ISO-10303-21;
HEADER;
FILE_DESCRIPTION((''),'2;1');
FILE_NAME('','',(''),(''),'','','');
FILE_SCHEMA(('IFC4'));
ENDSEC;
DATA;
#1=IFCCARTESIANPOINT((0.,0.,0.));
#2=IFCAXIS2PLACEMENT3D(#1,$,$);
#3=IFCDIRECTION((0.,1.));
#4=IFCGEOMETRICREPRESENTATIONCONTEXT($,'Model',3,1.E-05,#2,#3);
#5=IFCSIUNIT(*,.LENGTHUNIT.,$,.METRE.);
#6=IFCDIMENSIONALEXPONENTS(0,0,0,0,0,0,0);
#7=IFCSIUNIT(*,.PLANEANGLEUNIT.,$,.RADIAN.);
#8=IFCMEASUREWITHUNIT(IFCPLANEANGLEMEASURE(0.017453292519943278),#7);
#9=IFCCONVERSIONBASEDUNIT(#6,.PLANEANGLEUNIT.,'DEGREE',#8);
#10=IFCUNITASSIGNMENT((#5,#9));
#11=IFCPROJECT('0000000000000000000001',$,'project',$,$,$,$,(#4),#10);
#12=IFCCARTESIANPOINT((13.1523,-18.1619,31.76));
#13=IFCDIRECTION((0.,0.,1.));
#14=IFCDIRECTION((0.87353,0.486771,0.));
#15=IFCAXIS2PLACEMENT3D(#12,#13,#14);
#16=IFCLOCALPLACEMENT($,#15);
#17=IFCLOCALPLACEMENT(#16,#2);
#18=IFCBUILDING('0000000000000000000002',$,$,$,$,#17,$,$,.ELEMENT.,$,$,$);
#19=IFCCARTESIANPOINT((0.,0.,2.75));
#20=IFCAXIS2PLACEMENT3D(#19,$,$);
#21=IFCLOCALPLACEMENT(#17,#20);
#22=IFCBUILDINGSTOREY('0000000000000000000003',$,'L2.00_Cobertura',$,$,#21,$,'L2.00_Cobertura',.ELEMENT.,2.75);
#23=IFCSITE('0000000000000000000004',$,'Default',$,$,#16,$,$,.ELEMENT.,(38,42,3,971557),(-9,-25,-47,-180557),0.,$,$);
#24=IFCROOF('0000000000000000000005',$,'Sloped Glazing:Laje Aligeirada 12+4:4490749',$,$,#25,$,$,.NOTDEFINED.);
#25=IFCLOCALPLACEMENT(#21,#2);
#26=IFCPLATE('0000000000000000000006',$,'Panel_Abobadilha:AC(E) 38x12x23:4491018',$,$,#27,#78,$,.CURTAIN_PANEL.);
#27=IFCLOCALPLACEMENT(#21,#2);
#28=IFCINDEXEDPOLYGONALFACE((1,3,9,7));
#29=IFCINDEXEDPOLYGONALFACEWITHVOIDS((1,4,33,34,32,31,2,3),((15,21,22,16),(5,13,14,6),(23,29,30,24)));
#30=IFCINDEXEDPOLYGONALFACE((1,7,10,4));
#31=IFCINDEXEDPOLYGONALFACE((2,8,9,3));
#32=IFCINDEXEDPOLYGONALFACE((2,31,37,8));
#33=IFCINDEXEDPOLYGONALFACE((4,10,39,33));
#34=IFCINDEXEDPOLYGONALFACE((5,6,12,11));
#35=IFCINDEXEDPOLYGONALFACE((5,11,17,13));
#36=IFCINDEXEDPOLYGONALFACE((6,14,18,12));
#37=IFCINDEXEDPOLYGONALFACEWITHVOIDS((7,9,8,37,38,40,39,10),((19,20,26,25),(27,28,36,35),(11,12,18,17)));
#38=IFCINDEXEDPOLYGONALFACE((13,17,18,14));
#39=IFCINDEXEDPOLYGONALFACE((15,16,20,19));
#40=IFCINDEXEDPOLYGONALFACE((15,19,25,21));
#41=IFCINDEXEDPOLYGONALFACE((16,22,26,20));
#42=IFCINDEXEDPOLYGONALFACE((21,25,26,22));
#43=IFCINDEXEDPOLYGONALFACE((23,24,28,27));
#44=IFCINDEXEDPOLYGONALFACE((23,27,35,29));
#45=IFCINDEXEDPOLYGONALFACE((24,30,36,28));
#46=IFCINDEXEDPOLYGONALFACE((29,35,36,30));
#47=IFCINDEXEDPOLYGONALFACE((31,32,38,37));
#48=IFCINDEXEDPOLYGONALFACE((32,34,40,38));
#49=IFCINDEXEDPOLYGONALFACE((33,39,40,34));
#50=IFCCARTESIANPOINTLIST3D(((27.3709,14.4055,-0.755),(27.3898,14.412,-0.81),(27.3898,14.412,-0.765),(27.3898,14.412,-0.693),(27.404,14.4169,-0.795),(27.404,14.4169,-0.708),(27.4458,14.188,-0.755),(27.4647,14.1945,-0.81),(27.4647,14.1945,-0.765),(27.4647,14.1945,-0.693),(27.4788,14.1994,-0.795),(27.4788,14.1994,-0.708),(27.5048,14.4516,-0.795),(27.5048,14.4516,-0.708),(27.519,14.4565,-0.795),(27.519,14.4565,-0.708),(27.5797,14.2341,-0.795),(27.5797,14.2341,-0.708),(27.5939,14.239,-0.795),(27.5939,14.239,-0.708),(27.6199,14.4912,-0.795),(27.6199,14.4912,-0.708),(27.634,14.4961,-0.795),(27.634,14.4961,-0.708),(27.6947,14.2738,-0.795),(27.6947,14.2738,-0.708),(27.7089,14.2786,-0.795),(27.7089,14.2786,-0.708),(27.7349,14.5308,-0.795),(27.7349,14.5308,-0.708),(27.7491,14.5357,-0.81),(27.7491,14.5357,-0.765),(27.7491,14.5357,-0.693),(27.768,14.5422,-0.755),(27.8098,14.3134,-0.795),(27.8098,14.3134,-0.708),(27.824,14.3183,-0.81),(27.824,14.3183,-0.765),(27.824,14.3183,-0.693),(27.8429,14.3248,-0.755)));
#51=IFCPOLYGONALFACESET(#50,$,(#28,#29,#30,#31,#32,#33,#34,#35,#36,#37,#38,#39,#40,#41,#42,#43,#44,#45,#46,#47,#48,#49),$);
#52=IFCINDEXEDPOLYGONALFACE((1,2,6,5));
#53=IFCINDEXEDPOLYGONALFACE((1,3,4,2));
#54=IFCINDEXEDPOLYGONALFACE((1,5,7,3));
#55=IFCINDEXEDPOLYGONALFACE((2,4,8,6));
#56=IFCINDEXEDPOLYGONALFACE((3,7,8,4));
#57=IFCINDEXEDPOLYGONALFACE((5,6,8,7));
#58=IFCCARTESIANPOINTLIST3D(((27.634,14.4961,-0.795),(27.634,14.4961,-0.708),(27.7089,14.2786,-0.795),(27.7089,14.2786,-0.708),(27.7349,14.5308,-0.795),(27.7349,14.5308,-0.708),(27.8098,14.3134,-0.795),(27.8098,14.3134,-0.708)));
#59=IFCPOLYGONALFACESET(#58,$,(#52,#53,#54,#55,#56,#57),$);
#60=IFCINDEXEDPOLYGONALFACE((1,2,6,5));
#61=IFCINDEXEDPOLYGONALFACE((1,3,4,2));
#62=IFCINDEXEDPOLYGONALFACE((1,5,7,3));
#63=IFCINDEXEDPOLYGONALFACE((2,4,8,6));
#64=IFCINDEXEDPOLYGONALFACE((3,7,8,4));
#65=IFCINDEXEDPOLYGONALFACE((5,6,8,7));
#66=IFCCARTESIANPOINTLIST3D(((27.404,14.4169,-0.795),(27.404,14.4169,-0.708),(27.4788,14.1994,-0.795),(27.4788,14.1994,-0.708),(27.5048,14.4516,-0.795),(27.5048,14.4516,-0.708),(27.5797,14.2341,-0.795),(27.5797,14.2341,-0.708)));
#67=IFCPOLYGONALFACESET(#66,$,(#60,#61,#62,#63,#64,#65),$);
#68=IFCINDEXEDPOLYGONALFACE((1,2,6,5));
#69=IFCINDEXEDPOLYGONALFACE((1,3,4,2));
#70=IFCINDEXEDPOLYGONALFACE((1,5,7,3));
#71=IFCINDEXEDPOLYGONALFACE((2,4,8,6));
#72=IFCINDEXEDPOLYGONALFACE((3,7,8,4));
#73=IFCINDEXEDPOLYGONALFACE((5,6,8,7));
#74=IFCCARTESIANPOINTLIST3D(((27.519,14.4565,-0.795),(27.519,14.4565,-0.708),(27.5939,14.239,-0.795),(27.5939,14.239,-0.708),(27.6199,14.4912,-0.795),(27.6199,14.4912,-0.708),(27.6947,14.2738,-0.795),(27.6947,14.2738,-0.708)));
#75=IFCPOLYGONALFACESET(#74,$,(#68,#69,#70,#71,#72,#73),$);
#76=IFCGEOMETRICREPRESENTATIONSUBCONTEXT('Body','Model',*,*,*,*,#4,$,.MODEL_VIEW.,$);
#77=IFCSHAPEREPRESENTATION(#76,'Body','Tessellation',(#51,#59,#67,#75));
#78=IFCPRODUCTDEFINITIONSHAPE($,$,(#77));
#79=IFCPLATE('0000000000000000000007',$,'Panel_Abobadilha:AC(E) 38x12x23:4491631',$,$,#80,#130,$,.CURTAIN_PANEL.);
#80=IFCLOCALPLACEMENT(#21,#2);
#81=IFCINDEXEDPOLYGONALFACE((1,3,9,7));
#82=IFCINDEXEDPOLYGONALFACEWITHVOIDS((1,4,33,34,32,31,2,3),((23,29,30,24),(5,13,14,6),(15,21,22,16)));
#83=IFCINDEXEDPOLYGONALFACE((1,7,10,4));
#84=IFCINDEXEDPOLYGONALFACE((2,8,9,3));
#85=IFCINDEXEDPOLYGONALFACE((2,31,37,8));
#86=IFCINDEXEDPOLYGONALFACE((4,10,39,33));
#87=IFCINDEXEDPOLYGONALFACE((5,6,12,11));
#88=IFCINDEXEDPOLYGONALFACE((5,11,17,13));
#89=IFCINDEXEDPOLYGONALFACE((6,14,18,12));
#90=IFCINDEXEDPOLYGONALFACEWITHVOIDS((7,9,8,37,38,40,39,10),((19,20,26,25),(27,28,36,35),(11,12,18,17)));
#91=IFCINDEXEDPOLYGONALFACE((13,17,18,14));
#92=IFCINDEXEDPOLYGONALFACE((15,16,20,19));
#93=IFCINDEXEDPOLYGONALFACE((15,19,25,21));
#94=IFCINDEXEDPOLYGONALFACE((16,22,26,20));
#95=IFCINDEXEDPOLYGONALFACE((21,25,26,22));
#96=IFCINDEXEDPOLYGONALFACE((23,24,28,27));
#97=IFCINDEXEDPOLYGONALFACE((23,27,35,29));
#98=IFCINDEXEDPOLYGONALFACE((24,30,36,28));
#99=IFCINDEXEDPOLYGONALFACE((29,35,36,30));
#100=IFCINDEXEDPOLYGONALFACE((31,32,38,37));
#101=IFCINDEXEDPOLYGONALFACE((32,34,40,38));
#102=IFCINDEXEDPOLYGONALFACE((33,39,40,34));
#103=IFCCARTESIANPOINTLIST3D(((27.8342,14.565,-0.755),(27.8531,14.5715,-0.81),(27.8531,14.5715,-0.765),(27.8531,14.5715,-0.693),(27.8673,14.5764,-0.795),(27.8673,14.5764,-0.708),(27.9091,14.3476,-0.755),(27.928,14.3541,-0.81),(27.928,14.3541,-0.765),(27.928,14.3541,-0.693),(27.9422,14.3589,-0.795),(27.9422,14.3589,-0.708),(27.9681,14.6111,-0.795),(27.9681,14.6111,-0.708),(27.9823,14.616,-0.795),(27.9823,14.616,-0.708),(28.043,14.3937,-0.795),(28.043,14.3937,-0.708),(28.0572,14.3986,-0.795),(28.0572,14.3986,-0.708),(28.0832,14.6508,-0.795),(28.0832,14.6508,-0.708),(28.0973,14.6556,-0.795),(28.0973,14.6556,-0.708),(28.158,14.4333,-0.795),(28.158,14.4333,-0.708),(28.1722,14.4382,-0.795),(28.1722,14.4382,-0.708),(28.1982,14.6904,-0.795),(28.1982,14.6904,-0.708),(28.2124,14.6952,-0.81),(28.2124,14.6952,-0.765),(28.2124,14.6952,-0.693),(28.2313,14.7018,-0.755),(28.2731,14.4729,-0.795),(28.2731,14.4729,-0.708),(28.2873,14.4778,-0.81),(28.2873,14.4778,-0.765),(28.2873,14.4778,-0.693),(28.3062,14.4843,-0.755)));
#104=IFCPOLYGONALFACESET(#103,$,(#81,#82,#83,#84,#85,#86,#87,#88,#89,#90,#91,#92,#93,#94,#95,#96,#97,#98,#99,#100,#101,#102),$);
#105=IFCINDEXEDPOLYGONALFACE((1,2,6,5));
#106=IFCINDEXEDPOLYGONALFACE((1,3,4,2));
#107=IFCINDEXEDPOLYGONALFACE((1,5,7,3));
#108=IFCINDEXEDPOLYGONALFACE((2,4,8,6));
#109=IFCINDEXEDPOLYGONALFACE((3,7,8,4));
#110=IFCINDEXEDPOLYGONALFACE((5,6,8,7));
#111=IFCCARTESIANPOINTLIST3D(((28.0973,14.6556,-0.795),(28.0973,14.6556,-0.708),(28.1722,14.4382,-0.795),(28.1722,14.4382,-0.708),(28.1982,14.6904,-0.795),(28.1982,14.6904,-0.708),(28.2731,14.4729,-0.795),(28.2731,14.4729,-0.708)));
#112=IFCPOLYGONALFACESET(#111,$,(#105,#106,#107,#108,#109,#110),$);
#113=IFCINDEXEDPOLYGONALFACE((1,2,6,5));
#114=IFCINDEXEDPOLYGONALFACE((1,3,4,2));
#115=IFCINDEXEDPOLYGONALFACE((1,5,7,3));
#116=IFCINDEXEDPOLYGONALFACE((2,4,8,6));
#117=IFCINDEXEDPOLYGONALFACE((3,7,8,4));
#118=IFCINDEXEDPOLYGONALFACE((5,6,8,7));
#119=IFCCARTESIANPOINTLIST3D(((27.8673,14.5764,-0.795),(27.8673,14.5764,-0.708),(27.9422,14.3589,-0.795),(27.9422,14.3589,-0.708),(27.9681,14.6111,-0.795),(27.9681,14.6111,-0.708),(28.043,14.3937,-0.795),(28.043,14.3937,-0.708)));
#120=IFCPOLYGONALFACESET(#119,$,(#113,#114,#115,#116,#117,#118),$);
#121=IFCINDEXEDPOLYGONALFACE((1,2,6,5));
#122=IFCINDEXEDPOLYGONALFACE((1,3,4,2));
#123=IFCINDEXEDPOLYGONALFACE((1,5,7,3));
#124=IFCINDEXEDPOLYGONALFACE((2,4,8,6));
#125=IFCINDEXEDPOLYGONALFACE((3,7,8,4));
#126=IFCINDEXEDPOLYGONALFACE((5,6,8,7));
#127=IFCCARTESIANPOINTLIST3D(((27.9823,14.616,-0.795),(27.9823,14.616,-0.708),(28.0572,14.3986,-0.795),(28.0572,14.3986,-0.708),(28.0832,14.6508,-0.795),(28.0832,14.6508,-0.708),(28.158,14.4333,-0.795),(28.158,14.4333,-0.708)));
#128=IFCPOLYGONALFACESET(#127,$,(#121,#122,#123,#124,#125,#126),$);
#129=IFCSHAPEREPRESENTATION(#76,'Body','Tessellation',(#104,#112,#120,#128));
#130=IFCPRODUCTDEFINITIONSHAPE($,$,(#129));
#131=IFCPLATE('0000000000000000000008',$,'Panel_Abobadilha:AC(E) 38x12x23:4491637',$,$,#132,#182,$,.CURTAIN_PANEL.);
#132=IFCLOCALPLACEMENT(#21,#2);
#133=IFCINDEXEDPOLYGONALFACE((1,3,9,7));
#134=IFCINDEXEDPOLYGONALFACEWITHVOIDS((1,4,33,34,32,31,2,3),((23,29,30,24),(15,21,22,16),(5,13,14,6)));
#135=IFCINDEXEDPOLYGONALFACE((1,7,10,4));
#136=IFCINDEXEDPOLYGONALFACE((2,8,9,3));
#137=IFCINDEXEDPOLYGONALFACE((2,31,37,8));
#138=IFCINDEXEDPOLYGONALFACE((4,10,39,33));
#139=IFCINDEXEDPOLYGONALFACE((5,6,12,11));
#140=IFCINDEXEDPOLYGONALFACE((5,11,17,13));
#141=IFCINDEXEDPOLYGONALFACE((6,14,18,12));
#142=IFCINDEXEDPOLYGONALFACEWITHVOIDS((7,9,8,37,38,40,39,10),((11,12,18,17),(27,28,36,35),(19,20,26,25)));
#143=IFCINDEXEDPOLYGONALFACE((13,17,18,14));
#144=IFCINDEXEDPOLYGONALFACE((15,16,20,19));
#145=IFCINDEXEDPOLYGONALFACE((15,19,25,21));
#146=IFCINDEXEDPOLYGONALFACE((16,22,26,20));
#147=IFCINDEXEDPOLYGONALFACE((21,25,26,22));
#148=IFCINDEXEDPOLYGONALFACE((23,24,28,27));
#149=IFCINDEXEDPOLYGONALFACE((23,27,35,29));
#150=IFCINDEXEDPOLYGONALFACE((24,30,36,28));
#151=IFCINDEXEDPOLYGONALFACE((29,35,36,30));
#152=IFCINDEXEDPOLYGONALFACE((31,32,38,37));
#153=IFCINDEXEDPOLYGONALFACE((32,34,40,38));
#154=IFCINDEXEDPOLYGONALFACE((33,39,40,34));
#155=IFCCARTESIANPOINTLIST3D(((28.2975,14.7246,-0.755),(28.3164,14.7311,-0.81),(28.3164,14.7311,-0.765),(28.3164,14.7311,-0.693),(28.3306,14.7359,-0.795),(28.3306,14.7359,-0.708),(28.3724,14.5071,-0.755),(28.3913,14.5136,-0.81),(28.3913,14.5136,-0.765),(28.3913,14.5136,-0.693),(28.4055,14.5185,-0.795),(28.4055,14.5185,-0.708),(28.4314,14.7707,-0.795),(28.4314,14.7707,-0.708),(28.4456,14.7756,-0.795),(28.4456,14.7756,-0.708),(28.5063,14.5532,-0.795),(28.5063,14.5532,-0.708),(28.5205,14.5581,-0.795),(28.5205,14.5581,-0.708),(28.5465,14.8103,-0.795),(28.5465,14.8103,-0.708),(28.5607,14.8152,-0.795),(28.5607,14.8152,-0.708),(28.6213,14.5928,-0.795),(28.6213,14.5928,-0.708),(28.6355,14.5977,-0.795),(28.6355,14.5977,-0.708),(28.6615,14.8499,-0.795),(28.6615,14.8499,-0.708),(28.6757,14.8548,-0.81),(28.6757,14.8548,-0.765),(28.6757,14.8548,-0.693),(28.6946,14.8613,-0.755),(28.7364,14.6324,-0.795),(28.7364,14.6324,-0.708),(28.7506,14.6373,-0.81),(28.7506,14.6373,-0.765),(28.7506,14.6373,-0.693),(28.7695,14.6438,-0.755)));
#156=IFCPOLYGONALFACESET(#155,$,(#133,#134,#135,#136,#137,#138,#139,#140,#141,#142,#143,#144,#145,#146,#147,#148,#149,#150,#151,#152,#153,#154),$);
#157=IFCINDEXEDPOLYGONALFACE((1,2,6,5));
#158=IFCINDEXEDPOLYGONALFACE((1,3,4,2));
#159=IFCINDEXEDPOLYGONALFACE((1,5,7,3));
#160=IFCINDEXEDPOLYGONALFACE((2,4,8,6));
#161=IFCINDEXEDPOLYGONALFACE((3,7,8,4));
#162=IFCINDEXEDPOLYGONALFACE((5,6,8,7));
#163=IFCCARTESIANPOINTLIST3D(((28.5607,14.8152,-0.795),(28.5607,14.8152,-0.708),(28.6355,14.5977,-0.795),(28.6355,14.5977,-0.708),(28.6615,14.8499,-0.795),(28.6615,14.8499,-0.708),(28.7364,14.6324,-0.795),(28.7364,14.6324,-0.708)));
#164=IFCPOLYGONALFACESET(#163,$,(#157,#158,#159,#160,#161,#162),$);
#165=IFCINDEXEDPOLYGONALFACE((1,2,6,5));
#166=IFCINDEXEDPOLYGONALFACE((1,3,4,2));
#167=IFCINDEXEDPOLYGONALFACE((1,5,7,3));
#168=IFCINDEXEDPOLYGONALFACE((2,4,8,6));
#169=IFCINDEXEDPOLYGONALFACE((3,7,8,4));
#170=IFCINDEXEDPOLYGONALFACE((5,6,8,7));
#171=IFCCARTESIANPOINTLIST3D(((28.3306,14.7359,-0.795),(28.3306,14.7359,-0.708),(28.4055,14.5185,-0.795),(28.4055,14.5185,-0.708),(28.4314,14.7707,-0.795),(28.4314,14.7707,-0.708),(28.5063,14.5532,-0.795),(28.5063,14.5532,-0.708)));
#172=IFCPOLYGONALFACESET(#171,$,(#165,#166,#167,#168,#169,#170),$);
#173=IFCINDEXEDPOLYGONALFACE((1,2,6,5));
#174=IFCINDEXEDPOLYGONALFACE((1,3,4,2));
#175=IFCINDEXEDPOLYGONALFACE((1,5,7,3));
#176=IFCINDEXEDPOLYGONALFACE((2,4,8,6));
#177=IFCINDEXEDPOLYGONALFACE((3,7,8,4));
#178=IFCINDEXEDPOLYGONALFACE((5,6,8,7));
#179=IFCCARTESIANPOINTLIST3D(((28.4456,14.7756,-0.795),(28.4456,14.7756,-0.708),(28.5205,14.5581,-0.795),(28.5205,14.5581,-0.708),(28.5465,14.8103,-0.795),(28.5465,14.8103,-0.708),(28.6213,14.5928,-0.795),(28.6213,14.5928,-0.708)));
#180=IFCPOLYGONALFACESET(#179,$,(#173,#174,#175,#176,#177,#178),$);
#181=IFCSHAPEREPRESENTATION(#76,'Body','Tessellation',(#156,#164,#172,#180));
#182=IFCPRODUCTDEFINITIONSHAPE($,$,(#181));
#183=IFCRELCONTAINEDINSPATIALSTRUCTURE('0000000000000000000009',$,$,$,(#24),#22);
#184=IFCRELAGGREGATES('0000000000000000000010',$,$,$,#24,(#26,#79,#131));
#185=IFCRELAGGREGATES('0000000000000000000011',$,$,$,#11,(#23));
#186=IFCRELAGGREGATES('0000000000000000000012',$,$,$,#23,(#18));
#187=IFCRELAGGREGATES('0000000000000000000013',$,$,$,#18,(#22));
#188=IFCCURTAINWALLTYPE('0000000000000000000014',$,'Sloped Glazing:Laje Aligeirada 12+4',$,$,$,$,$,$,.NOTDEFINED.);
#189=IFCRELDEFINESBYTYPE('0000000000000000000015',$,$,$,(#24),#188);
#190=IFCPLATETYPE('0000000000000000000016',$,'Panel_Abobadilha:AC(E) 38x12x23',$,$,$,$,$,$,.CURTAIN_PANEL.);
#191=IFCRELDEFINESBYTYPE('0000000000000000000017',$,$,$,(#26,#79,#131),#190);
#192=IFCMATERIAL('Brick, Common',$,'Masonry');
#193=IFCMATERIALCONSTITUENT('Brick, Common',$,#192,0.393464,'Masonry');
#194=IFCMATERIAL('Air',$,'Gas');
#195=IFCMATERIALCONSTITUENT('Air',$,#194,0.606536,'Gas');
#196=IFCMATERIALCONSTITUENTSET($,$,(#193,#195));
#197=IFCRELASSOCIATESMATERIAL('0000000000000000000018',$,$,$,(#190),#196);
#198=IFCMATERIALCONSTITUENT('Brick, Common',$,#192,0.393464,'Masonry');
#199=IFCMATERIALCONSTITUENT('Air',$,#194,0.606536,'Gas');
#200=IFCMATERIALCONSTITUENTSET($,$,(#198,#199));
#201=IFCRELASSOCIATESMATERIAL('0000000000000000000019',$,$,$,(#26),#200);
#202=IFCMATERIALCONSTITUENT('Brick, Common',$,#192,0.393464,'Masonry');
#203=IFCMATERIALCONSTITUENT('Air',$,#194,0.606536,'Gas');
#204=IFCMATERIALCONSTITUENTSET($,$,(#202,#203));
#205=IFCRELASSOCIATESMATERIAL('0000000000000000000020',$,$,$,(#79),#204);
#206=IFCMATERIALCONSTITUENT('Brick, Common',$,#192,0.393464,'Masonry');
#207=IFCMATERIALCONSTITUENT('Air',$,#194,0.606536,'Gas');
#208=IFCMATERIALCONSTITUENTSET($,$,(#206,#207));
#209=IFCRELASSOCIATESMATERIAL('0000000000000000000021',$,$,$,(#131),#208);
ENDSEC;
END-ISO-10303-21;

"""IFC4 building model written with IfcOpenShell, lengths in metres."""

from ifc_helpers import new_model, entity, si_unit, converted_unit, direction, frame, origin, place, context, subcontext, project, spatial, indexed_curve, outline, extrude, source, transform, mapped, material, constituent, constituent_set, type_object, type_shapes, element, aggregate, save


model = new_model("IFC4")

# Units and contexts
model_context = context("Model", 3, precision=1e-05, world=origin(), true_north=direction((0.0, 1.0)))
body_context = subcontext(model_context, "Body", "Model", "MODEL_VIEW")
ifc_project = project(units=[si_unit("LENGTHUNIT", "METRE"), converted_unit("PLANEANGLEUNIT", "DEGREE", entity("IfcPlaneAngleMeasure", 0.017453292519943278), si_unit("PLANEANGLEUNIT", "RADIAN"), dimensions=[0, 0, 0, 0, 0, 0, 0])], contexts=[model_context])

# Site, building, storey
site_placement = place(None, frame((13.1523, -18.1619, 31.76), z_axis=(0.0, 0.0, 1.0), x_axis=(0.87353, 0.486771, 0.0)))
site = spatial("IfcSite", under=ifc_project, at=site_placement, Name="Default", CompositionType="ELEMENT", RefLatitude=(38, 42, 3, 971557), RefLongitude=(-9, -25, -47, -180557), RefElevation=0.0)
building_placement = place(site_placement, origin())
building = spatial("IfcBuilding", under=site, at=building_placement, CompositionType="ELEMENT")
storey_placement = place(building_placement, frame((0.0, 0.0, 2.75)))
storey = spatial("IfcBuildingStorey", under=building, at=storey_placement, Name="L2.00_Cobertura", LongName="L2.00_Cobertura", CompositionType="ELEMENT", Elevation=2.75)

# Roof, plates
curtain_wall_type = type_object("IfcCurtainWallType", Name="Sloped Glazing:Laje Aligeirada 12+4", PredefinedType="NOTDEFINED")
roof_placement = place(storey_placement, frame((0.0, 0.0, -2.75)))
roof = element("IfcRoof", 1, at=roof_placement, inside=storey, type_object=curtain_wall_type, Name="Sloped Glazing:Laje Aligeirada 12+4:4490749", PredefinedType="NOTDEFINED")
ifc_material_1 = material(Name="Brick, Common", Category="Masonry")
ifc_material_2 = material(Name="Air", Category="Gas")
ifc_constituent_1 = constituent(ifc_material_1, Name="Brick, Common", Category="Masonry", fraction=0.393464)
ifc_constituent_2 = constituent(ifc_material_2, Name="Air", Category="Gas", fraction=0.606536)
ifc_constituent_set_1 = constituent_set(constituents=[ifc_constituent_1, ifc_constituent_2])
plate_type = type_object("IfcPlateType", Name="Panel_Abobadilha:AC(E) 38x12x23", PredefinedType="CURTAIN_PANEL", material=ifc_constituent_set_1)
shared_shape_1 = source(origin(), body_context, "Body", "SweptSolid", [
    extrude(outline(indexed_curve([(-0.19, -0.0543), (0.19, -0.0543), (0.19, -0.0093), (0.21, 0.0007), (0.19, 0.0628), (-0.19, 0.0628), (-0.21, 0.0007), (-0.19, -0.0093), (-0.19, -0.0543)], self_intersect=False), holes=[indexed_curve([(-0.0683, 0.0477), (-0.0683, -0.0393), (-0.175, -0.0393), (-0.175, 0.0477), (-0.0683, 0.0477)], self_intersect=False), indexed_curve([(0.0533, 0.0477), (0.0533, -0.0393), (-0.0533, -0.0393), (-0.0533, 0.0477), (0.0533, 0.0477)], self_intersect=False), indexed_curve([(0.175, 0.0477), (0.175, -0.0393), (0.0683, -0.0393), (0.0683, 0.0477), (0.175, 0.0477)], self_intersect=False)]), frame((0.0, 0.0543, 0.0)), (0.0, 0.0, 1.0), 0.23),
    extrude(outline(indexed_curve([(-0.0533, -0.0435), (0.0533, -0.0435), (0.0533, 0.0435), (-0.0533, 0.0435), (-0.0533, -0.0435)], self_intersect=False)), frame((0.1217, 0.0585, 0.0), z_axis=(0.0, 0.0, 1.0), x_axis=(-1.0, 0.0, 0.0)), (0.0, 0.0, 1.0), 0.23),
    extrude(outline(indexed_curve([(-0.0533, -0.0435), (0.0533, -0.0435), (0.0533, 0.0435), (-0.0533, 0.0435), (-0.0533, -0.0435)], self_intersect=False)), frame((-0.1217, 0.0585, 0.0), z_axis=(0.0, 0.0, 1.0), x_axis=(-1.0, 0.0, 0.0)), (0.0, 0.0, 1.0), 0.23),
    extrude(outline(indexed_curve([(-0.0533, -0.0435), (0.0533, -0.0435), (0.0533, 0.0435), (-0.0533, 0.0435), (-0.0533, -0.0435)], self_intersect=False)), frame((0.0, 0.0585, 0.0), z_axis=(0.0, 0.0, 1.0), x_axis=(-1.0, 0.0, 0.0)), (0.0, 0.0, 1.0), 0.23),
])
type_shapes(plate_type, [shared_shape_1])
ifc_constituent_3 = constituent(ifc_material_1, Name="Brick, Common", Category="Masonry", fraction=0.393464)
ifc_constituent_4 = constituent(ifc_material_2, Name="Air", Category="Gas", fraction=0.606536)
ifc_constituent_set_2 = constituent_set(constituents=[ifc_constituent_3, ifc_constituent_4])
plate_1_placement = place(roof_placement, frame((27.5694, 14.4739, 1.94), z_axis=(0.325568, -0.945519, 0.0), x_axis=(0.945519, 0.325568, 0.0)))
plate_1 = element("IfcPlate", 2, at=plate_1_placement, type_object=plate_type, material=ifc_constituent_set_2, Name="Panel_Abobadilha:AC(E) 38x12x23:4491018", PredefinedType="CURTAIN_PANEL", context=body_context, shape_type="MappedRepresentation", body=[
    mapped(shared_shape_1, transform((0.0, 0.0, 0.0), scale=1.0)),
])
ifc_constituent_5 = constituent(ifc_material_1, Name="Brick, Common", Category="Masonry", fraction=0.393464)
ifc_constituent_6 = constituent(ifc_material_2, Name="Air", Category="Gas", fraction=0.606536)
ifc_constituent_set_3 = constituent_set(constituents=[ifc_constituent_5, ifc_constituent_6])
plate_2_placement = place(roof_placement, frame((28.0327, 14.6334, 1.94), z_axis=(0.325568, -0.945519, 0.0), x_axis=(0.945519, 0.325568, 0.0)))
plate_2 = element("IfcPlate", 3, at=plate_2_placement, type_object=plate_type, material=ifc_constituent_set_3, Name="Panel_Abobadilha:AC(E) 38x12x23:4491631", PredefinedType="CURTAIN_PANEL", context=body_context, shape_type="MappedRepresentation", body=[
    mapped(shared_shape_1, transform((0.0, 0.0, 0.0), scale=1.0)),
])
ifc_constituent_7 = constituent(ifc_material_1, Name="Brick, Common", Category="Masonry", fraction=0.393464)
ifc_constituent_8 = constituent(ifc_material_2, Name="Air", Category="Gas", fraction=0.606536)
ifc_constituent_set_4 = constituent_set(constituents=[ifc_constituent_7, ifc_constituent_8])
plate_3_placement = place(roof_placement, frame((28.496, 14.7929, 1.94), z_axis=(0.325568, -0.945519, 0.0), x_axis=(0.945519, 0.325568, 0.0)))
plate_3 = element("IfcPlate", 4, at=plate_3_placement, type_object=plate_type, material=ifc_constituent_set_4, Name="Panel_Abobadilha:AC(E) 38x12x23:4491637", PredefinedType="CURTAIN_PANEL", context=body_context, shape_type="MappedRepresentation", body=[
    mapped(shared_shape_1, transform((0.0, 0.0, 0.0), scale=1.0)),
])
aggregate(roof, [plate_1, plate_2, plate_3])

save(model, "model.ifc")
